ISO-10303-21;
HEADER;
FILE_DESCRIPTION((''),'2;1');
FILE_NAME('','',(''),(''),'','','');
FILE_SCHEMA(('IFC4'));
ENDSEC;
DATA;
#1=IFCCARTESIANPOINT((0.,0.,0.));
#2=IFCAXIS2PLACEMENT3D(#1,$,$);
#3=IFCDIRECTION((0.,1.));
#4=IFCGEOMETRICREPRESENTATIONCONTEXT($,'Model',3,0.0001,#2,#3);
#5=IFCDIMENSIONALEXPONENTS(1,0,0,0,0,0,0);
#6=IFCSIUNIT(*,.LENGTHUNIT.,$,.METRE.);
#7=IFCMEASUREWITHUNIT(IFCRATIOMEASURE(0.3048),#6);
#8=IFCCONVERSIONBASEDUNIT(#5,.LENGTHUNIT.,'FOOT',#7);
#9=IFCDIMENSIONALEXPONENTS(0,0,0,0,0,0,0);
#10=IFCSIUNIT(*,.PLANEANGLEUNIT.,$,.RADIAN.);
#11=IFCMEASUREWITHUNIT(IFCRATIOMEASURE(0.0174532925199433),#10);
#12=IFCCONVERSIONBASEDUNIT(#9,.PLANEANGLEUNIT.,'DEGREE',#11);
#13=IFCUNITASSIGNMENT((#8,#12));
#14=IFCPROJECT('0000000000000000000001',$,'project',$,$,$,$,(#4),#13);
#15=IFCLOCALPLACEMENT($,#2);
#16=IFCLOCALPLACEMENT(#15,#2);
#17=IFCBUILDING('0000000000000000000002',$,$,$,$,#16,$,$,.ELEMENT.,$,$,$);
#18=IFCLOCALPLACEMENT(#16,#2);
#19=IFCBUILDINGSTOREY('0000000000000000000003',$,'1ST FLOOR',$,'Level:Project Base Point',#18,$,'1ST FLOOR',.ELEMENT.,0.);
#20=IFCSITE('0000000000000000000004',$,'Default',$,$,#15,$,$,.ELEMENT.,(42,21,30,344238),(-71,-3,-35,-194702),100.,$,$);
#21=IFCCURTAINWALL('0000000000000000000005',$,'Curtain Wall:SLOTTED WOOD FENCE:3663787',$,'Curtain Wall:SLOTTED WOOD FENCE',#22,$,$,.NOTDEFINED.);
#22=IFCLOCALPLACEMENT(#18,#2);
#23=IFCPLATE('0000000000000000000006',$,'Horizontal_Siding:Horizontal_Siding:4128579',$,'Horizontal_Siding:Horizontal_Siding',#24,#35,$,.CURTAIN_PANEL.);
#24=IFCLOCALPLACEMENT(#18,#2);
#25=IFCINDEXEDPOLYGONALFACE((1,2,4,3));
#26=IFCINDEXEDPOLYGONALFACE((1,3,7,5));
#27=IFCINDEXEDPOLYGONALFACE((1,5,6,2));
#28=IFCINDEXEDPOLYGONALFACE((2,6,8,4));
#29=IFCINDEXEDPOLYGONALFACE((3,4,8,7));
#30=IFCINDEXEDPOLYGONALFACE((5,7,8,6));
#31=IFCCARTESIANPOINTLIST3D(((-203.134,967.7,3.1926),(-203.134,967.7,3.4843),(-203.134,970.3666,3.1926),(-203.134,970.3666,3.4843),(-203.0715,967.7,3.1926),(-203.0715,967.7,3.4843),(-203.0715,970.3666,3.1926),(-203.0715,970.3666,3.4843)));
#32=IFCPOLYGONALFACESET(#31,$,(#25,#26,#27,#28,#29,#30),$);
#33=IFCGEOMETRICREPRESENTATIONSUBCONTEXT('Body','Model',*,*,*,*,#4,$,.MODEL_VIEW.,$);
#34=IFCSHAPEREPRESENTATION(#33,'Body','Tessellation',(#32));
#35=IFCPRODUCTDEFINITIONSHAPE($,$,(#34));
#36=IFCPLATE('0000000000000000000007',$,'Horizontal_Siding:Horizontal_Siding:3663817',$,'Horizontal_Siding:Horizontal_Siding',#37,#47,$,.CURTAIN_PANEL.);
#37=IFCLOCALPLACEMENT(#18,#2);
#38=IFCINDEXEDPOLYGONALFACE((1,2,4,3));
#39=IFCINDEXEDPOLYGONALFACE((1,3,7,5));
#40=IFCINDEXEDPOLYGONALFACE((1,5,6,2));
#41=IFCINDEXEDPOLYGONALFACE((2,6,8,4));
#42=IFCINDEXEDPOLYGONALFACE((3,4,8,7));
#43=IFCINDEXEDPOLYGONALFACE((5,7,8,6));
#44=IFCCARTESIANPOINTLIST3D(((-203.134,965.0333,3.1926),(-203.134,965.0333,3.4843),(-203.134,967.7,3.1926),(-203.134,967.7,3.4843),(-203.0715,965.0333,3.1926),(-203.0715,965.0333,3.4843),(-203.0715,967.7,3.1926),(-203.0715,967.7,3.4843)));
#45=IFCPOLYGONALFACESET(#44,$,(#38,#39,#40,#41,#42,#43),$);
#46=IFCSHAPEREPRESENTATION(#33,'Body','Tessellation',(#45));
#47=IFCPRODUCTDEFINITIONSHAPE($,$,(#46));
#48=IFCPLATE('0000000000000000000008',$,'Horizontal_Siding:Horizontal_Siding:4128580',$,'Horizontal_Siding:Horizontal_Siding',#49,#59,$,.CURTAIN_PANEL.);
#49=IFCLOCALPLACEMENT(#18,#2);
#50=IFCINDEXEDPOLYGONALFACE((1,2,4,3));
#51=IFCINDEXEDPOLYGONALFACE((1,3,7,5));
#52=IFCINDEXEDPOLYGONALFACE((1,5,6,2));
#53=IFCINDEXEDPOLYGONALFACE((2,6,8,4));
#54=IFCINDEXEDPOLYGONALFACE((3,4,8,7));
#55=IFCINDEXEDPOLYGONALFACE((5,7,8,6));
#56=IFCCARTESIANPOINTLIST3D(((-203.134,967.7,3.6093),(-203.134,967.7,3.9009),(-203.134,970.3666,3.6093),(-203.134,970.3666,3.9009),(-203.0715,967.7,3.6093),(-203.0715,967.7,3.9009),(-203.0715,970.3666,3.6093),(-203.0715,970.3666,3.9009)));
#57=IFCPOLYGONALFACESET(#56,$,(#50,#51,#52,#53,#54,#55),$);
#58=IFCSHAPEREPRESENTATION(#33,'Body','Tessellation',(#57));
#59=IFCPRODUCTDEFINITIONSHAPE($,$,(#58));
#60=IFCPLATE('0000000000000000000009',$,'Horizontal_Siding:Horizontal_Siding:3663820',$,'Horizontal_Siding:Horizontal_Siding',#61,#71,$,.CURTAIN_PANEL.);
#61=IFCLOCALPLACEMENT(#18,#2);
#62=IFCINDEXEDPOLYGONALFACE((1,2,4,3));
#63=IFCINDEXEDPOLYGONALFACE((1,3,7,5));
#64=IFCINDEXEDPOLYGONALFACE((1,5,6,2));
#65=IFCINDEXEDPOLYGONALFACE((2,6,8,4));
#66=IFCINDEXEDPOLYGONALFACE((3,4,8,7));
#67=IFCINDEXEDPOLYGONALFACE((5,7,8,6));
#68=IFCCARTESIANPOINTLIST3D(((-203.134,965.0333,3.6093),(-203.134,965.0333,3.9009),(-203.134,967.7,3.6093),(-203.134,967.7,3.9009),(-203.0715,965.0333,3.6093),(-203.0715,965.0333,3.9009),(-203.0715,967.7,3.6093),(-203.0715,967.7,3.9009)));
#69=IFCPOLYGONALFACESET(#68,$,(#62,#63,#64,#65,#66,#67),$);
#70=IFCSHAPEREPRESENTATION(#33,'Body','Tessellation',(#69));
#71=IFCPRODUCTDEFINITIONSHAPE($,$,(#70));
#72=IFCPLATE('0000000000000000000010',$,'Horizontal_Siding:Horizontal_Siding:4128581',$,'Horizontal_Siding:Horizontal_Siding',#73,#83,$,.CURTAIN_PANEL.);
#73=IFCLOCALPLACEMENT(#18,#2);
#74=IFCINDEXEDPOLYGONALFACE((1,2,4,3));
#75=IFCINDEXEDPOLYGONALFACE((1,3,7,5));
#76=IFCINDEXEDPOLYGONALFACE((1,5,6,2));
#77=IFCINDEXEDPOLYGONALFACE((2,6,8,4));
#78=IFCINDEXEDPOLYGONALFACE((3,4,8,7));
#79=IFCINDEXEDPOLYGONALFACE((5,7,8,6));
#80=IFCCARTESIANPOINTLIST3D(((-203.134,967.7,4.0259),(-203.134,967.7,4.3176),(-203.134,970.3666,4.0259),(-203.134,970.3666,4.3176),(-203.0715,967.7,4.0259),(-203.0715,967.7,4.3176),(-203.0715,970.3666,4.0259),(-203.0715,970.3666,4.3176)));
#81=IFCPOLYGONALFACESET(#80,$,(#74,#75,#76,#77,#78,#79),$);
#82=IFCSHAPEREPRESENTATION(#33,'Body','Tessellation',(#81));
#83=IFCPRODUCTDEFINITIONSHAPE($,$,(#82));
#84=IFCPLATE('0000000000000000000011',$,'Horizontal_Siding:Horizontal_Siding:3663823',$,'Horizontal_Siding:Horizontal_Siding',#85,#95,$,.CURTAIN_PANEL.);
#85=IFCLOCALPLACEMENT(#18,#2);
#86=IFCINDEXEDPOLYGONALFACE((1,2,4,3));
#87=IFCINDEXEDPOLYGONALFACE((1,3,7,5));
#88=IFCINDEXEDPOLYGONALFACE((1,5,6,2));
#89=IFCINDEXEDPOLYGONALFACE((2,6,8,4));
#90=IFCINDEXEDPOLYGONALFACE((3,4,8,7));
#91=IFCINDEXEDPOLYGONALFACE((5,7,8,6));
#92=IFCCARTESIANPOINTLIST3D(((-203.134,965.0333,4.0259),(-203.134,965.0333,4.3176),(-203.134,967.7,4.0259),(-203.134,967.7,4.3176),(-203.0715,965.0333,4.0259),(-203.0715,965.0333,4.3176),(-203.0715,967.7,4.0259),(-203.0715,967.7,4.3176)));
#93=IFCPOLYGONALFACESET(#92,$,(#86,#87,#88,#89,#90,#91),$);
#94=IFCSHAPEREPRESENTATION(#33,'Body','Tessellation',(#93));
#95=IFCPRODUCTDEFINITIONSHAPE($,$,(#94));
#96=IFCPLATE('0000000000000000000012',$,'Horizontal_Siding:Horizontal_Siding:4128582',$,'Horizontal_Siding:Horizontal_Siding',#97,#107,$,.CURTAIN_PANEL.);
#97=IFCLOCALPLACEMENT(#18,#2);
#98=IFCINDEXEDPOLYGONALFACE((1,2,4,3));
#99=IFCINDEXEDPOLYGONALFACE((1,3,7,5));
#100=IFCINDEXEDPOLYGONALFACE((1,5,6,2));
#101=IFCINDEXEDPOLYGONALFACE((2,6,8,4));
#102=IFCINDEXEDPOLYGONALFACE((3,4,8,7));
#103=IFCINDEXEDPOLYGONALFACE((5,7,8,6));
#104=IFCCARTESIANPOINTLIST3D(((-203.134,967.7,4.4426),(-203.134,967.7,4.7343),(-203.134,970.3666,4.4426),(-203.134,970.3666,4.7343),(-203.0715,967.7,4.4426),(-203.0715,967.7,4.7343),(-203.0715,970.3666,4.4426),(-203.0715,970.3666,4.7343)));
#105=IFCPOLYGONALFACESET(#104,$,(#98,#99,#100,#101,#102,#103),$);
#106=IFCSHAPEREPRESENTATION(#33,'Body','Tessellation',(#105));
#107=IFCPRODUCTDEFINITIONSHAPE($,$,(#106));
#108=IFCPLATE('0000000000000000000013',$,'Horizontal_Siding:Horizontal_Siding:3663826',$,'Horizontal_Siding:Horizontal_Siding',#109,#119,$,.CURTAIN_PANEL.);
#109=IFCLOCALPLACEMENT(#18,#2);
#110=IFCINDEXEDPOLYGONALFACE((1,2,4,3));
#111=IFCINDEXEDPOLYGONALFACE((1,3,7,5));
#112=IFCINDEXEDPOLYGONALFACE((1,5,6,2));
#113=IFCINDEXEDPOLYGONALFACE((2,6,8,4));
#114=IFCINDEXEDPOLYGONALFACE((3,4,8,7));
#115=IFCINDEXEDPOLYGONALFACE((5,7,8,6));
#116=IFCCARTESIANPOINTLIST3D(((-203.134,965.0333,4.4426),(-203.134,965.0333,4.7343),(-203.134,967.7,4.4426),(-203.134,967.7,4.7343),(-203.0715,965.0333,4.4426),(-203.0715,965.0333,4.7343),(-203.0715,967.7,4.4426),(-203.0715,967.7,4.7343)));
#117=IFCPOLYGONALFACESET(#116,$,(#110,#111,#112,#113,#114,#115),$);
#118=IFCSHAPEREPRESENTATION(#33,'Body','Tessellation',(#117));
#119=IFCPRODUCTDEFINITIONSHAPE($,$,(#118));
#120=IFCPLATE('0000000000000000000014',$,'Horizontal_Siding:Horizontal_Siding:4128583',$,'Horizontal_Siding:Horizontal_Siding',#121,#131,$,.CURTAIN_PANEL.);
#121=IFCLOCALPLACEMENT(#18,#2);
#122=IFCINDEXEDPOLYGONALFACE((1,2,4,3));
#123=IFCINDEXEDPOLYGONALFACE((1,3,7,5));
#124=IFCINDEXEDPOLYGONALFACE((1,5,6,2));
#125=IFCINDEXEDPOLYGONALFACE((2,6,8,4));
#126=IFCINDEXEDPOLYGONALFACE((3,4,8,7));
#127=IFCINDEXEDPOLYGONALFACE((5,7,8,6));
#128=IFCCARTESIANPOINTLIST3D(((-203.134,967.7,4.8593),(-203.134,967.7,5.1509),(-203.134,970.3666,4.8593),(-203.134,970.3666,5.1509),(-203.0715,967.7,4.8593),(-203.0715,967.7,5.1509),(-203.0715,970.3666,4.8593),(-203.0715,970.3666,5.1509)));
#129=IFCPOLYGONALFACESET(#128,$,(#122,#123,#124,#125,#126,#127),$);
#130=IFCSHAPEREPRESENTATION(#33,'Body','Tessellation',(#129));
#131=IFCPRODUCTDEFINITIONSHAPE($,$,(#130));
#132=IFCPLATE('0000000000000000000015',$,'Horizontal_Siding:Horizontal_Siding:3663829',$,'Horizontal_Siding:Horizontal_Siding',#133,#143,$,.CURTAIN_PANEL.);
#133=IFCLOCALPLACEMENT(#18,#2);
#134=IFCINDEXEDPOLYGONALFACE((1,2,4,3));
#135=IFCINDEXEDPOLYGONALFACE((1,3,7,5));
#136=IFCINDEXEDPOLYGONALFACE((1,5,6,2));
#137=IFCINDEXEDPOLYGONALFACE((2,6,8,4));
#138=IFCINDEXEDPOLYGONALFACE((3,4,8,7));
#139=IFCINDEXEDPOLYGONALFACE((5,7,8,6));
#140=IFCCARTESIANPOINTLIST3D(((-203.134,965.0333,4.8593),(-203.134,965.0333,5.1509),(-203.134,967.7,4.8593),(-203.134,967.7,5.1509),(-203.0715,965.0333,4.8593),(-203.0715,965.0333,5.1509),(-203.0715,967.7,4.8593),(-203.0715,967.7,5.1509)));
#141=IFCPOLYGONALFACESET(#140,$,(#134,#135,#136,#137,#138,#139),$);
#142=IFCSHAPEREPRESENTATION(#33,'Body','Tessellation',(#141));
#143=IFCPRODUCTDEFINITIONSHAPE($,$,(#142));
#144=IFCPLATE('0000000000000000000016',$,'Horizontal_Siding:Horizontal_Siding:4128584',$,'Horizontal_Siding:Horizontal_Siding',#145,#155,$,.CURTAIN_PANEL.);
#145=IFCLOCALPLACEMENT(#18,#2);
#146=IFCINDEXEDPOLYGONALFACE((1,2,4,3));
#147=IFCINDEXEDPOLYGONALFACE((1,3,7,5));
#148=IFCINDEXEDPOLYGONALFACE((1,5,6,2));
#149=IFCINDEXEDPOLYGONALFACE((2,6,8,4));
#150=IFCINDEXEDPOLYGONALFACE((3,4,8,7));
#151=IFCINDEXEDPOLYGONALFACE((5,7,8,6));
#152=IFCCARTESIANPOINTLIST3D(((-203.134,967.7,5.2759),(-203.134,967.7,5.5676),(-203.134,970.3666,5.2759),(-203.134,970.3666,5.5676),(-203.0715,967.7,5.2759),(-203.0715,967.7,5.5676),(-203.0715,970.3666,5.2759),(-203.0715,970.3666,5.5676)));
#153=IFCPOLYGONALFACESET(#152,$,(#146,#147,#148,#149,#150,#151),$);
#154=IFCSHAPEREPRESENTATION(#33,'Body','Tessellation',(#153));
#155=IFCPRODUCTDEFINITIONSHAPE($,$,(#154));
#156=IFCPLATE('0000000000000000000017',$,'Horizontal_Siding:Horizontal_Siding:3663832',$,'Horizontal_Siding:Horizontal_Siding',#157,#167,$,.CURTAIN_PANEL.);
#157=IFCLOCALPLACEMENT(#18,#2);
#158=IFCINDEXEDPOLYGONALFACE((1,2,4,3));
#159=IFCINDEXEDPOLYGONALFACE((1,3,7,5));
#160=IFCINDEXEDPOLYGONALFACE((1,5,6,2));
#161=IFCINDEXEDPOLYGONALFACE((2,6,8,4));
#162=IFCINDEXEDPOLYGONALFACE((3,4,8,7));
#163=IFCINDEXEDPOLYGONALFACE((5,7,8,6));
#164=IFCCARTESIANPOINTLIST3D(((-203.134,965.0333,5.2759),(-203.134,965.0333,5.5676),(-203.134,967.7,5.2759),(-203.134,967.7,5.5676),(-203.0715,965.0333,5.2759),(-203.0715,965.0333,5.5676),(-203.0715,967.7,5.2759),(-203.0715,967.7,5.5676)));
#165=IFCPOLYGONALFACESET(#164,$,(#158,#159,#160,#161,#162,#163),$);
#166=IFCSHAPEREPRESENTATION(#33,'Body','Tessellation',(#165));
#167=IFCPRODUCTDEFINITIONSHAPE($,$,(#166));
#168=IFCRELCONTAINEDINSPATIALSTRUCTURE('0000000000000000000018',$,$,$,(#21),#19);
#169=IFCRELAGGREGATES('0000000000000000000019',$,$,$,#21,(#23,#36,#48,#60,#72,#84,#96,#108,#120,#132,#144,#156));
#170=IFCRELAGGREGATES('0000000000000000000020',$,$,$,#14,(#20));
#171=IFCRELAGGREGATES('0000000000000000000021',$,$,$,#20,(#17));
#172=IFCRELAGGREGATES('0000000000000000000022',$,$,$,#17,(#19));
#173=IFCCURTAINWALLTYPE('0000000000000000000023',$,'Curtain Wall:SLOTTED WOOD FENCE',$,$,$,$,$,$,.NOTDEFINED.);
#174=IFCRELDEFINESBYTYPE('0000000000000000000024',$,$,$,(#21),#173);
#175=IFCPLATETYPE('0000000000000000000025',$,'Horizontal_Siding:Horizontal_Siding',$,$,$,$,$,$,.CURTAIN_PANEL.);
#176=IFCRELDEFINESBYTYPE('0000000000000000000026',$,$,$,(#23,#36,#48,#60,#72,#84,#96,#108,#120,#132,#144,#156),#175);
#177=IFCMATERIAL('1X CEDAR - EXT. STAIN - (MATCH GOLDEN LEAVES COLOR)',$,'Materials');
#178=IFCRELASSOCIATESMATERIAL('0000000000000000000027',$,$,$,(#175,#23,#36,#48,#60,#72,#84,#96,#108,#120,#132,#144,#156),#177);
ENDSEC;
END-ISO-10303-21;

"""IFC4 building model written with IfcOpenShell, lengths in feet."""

from ifc_helpers import new_model, entity, si_unit, converted_unit, direction, frame, origin, origin_2d_with_axis, place, context, subcontext, project, spatial, rectangle, extrude, source, transform, mapped, material, type_object, type_shapes, element, aggregate, save


model = new_model("IFC4")

# Units and contexts
model_context = context("Model", 3, precision=0.0001, world=origin(), true_north=direction((0.0, 1.0)))
body_context = subcontext(model_context, "Body", "Model", "MODEL_VIEW")
ifc_project = project(units=[converted_unit("LENGTHUNIT", "FOOT", entity("IfcRatioMeasure", 0.3048), si_unit("LENGTHUNIT", "METRE"), dimensions=[1, 0, 0, 0, 0, 0, 0]), converted_unit("PLANEANGLEUNIT", "DEGREE", entity("IfcRatioMeasure", 0.0174532925199433), si_unit("PLANEANGLEUNIT", "RADIAN"), dimensions=[0, 0, 0, 0, 0, 0, 0])], contexts=[model_context])

# Site, building, storey
site_placement = place(None, origin())
site = spatial("IfcSite", under=ifc_project, at=site_placement, Name="Default", CompositionType="ELEMENT", RefLatitude=(42, 21, 30, 344238), RefLongitude=(-71, -3, -35, -194702), RefElevation=100.0)
building_placement = place(site_placement, origin())
building = spatial("IfcBuilding", under=site, at=building_placement, CompositionType="ELEMENT")
storey_placement = place(building_placement, origin())
storey = spatial("IfcBuildingStorey", under=building, at=storey_placement, Name="1ST FLOOR", ObjectType="Level:Project Base Point", LongName="1ST FLOOR", CompositionType="ELEMENT", Elevation=0.0)

# Curtain wall, plates
curtain_wall_type = type_object("IfcCurtainWallType", Name="Curtain Wall:SLOTTED WOOD FENCE", PredefinedType="NOTDEFINED")
curtain_wall_placement = place(storey_placement, origin())
curtain_wall = element("IfcCurtainWall", 1, at=curtain_wall_placement, inside=storey, type_object=curtain_wall_type, Name="Curtain Wall:SLOTTED WOOD FENCE:3663787", ObjectType="Curtain Wall:SLOTTED WOOD FENCE", PredefinedType="NOTDEFINED")
ifc_material_1 = material(Name="1X CEDAR - EXT. STAIN - (MATCH GOLDEN LEAVES COLOR)", Category="Materials")
plate_type = type_object("IfcPlateType", Name="Horizontal_Siding:Horizontal_Siding", PredefinedType="CURTAIN_PANEL", material=ifc_material_1)
shared_shape_1 = source(origin(), body_context, "Body", "SweptSolid", [
    extrude(rectangle(XDim=2.6667, YDim=0.0625, at=origin_2d_with_axis()), frame((1.3333, 0.0312, 0.0), z_axis=(0.0, 0.0, 1.0), x_axis=(-1.0, 0.0, 0.0)), (0.0, 0.0, 1.0), 0.2917),
])
type_shapes(plate_type, [shared_shape_1])
plate_1_placement = place(curtain_wall_placement, frame((-203.134, 970.3666, 3.1926), z_axis=(0.0, 0.0, 1.0), x_axis=(0.0, -1.0, 0.0)))
plate_1 = element("IfcPlate", 2, at=plate_1_placement, type_object=plate_type, material=ifc_material_1, Name="Horizontal_Siding:Horizontal_Siding:4128579", ObjectType="Horizontal_Siding:Horizontal_Siding", PredefinedType="CURTAIN_PANEL", context=body_context, shape_type="MappedRepresentation", body=[
    mapped(shared_shape_1, transform((0.0, 0.0, 0.0), scale=1.0)),
])
plate_2_placement = place(curtain_wall_placement, frame((-203.134, 967.7, 3.1926), z_axis=(0.0, 0.0, 1.0), x_axis=(0.0, -1.0, 0.0)))
plate_2 = element("IfcPlate", 3, at=plate_2_placement, type_object=plate_type, material=ifc_material_1, Name="Horizontal_Siding:Horizontal_Siding:3663817", ObjectType="Horizontal_Siding:Horizontal_Siding", PredefinedType="CURTAIN_PANEL", context=body_context, shape_type="MappedRepresentation", body=[
    mapped(shared_shape_1, transform((0.0, 0.0, 0.0), scale=1.0)),
])
plate_3_placement = place(curtain_wall_placement, frame((-203.134, 970.3666, 3.6093), z_axis=(0.0, 0.0, 1.0), x_axis=(0.0, -1.0, 0.0)))
plate_3 = element("IfcPlate", 4, at=plate_3_placement, type_object=plate_type, material=ifc_material_1, Name="Horizontal_Siding:Horizontal_Siding:4128580", ObjectType="Horizontal_Siding:Horizontal_Siding", PredefinedType="CURTAIN_PANEL", context=body_context, shape_type="MappedRepresentation", body=[
    mapped(shared_shape_1, transform((0.0, 0.0, 0.0), scale=1.0)),
])
plate_4_placement = place(curtain_wall_placement, frame((-203.134, 967.7, 3.6093), z_axis=(0.0, 0.0, 1.0), x_axis=(0.0, -1.0, 0.0)))
plate_4 = element("IfcPlate", 5, at=plate_4_placement, type_object=plate_type, material=ifc_material_1, Name="Horizontal_Siding:Horizontal_Siding:3663820", ObjectType="Horizontal_Siding:Horizontal_Siding", PredefinedType="CURTAIN_PANEL", context=body_context, shape_type="MappedRepresentation", body=[
    mapped(shared_shape_1, transform((0.0, 0.0, 0.0), scale=1.0)),
])
plate_5_placement = place(curtain_wall_placement, frame((-203.134, 970.3666, 4.0259), z_axis=(0.0, 0.0, 1.0), x_axis=(0.0, -1.0, 0.0)))
plate_5 = element("IfcPlate", 6, at=plate_5_placement, type_object=plate_type, material=ifc_material_1, Name="Horizontal_Siding:Horizontal_Siding:4128581", ObjectType="Horizontal_Siding:Horizontal_Siding", PredefinedType="CURTAIN_PANEL", context=body_context, shape_type="MappedRepresentation", body=[
    mapped(shared_shape_1, transform((0.0, 0.0, 0.0), scale=1.0)),
])
plate_6_placement = place(curtain_wall_placement, frame((-203.134, 967.7, 4.0259), z_axis=(0.0, 0.0, 1.0), x_axis=(0.0, -1.0, 0.0)))
plate_6 = element("IfcPlate", 7, at=plate_6_placement, type_object=plate_type, material=ifc_material_1, Name="Horizontal_Siding:Horizontal_Siding:3663823", ObjectType="Horizontal_Siding:Horizontal_Siding", PredefinedType="CURTAIN_PANEL", context=body_context, shape_type="MappedRepresentation", body=[
    mapped(shared_shape_1, transform((0.0, 0.0, 0.0), scale=1.0)),
])
plate_7_placement = place(curtain_wall_placement, frame((-203.134, 970.3666, 4.4426), z_axis=(0.0, 0.0, 1.0), x_axis=(0.0, -1.0, 0.0)))
plate_7 = element("IfcPlate", 8, at=plate_7_placement, type_object=plate_type, material=ifc_material_1, Name="Horizontal_Siding:Horizontal_Siding:4128582", ObjectType="Horizontal_Siding:Horizontal_Siding", PredefinedType="CURTAIN_PANEL", context=body_context, shape_type="MappedRepresentation", body=[
    mapped(shared_shape_1, transform((0.0, 0.0, 0.0), scale=1.0)),
])
plate_8_placement = place(curtain_wall_placement, frame((-203.134, 967.7, 4.4426), z_axis=(0.0, 0.0, 1.0), x_axis=(0.0, -1.0, 0.0)))
plate_8 = element("IfcPlate", 9, at=plate_8_placement, type_object=plate_type, material=ifc_material_1, Name="Horizontal_Siding:Horizontal_Siding:3663826", ObjectType="Horizontal_Siding:Horizontal_Siding", PredefinedType="CURTAIN_PANEL", context=body_context, shape_type="MappedRepresentation", body=[
    mapped(shared_shape_1, transform((0.0, 0.0, 0.0), scale=1.0)),
])
plate_9_placement = place(curtain_wall_placement, frame((-203.134, 970.3666, 4.8593), z_axis=(0.0, 0.0, 1.0), x_axis=(0.0, -1.0, 0.0)))
plate_9 = element("IfcPlate", 10, at=plate_9_placement, type_object=plate_type, material=ifc_material_1, Name="Horizontal_Siding:Horizontal_Siding:4128583", ObjectType="Horizontal_Siding:Horizontal_Siding", PredefinedType="CURTAIN_PANEL", context=body_context, shape_type="MappedRepresentation", body=[
    mapped(shared_shape_1, transform((0.0, 0.0, 0.0), scale=1.0)),
])
plate_10_placement = place(curtain_wall_placement, frame((-203.134, 967.7, 4.8593), z_axis=(0.0, 0.0, 1.0), x_axis=(0.0, -1.0, 0.0)))
plate_10 = element("IfcPlate", 11, at=plate_10_placement, type_object=plate_type, material=ifc_material_1, Name="Horizontal_Siding:Horizontal_Siding:3663829", ObjectType="Horizontal_Siding:Horizontal_Siding", PredefinedType="CURTAIN_PANEL", context=body_context, shape_type="MappedRepresentation", body=[
    mapped(shared_shape_1, transform((0.0, 0.0, 0.0), scale=1.0)),
])
plate_11_placement = place(curtain_wall_placement, frame((-203.134, 970.3666, 5.2759), z_axis=(0.0, 0.0, 1.0), x_axis=(0.0, -1.0, 0.0)))
plate_11 = element("IfcPlate", 12, at=plate_11_placement, type_object=plate_type, material=ifc_material_1, Name="Horizontal_Siding:Horizontal_Siding:4128584", ObjectType="Horizontal_Siding:Horizontal_Siding", PredefinedType="CURTAIN_PANEL", context=body_context, shape_type="MappedRepresentation", body=[
    mapped(shared_shape_1, transform((0.0, 0.0, 0.0), scale=1.0)),
])
plate_12_placement = place(curtain_wall_placement, frame((-203.134, 967.7, 5.2759), z_axis=(0.0, 0.0, 1.0), x_axis=(0.0, -1.0, 0.0)))
plate_12 = element("IfcPlate", 13, at=plate_12_placement, type_object=plate_type, material=ifc_material_1, Name="Horizontal_Siding:Horizontal_Siding:3663832", ObjectType="Horizontal_Siding:Horizontal_Siding", PredefinedType="CURTAIN_PANEL", context=body_context, shape_type="MappedRepresentation", body=[
    mapped(shared_shape_1, transform((0.0, 0.0, 0.0), scale=1.0)),
])
aggregate(curtain_wall, [plate_1, plate_2, plate_3, plate_4, plate_5, plate_6, plate_7, plate_8, plate_9, plate_10, plate_11, plate_12])

save(model, "model.ifc")
